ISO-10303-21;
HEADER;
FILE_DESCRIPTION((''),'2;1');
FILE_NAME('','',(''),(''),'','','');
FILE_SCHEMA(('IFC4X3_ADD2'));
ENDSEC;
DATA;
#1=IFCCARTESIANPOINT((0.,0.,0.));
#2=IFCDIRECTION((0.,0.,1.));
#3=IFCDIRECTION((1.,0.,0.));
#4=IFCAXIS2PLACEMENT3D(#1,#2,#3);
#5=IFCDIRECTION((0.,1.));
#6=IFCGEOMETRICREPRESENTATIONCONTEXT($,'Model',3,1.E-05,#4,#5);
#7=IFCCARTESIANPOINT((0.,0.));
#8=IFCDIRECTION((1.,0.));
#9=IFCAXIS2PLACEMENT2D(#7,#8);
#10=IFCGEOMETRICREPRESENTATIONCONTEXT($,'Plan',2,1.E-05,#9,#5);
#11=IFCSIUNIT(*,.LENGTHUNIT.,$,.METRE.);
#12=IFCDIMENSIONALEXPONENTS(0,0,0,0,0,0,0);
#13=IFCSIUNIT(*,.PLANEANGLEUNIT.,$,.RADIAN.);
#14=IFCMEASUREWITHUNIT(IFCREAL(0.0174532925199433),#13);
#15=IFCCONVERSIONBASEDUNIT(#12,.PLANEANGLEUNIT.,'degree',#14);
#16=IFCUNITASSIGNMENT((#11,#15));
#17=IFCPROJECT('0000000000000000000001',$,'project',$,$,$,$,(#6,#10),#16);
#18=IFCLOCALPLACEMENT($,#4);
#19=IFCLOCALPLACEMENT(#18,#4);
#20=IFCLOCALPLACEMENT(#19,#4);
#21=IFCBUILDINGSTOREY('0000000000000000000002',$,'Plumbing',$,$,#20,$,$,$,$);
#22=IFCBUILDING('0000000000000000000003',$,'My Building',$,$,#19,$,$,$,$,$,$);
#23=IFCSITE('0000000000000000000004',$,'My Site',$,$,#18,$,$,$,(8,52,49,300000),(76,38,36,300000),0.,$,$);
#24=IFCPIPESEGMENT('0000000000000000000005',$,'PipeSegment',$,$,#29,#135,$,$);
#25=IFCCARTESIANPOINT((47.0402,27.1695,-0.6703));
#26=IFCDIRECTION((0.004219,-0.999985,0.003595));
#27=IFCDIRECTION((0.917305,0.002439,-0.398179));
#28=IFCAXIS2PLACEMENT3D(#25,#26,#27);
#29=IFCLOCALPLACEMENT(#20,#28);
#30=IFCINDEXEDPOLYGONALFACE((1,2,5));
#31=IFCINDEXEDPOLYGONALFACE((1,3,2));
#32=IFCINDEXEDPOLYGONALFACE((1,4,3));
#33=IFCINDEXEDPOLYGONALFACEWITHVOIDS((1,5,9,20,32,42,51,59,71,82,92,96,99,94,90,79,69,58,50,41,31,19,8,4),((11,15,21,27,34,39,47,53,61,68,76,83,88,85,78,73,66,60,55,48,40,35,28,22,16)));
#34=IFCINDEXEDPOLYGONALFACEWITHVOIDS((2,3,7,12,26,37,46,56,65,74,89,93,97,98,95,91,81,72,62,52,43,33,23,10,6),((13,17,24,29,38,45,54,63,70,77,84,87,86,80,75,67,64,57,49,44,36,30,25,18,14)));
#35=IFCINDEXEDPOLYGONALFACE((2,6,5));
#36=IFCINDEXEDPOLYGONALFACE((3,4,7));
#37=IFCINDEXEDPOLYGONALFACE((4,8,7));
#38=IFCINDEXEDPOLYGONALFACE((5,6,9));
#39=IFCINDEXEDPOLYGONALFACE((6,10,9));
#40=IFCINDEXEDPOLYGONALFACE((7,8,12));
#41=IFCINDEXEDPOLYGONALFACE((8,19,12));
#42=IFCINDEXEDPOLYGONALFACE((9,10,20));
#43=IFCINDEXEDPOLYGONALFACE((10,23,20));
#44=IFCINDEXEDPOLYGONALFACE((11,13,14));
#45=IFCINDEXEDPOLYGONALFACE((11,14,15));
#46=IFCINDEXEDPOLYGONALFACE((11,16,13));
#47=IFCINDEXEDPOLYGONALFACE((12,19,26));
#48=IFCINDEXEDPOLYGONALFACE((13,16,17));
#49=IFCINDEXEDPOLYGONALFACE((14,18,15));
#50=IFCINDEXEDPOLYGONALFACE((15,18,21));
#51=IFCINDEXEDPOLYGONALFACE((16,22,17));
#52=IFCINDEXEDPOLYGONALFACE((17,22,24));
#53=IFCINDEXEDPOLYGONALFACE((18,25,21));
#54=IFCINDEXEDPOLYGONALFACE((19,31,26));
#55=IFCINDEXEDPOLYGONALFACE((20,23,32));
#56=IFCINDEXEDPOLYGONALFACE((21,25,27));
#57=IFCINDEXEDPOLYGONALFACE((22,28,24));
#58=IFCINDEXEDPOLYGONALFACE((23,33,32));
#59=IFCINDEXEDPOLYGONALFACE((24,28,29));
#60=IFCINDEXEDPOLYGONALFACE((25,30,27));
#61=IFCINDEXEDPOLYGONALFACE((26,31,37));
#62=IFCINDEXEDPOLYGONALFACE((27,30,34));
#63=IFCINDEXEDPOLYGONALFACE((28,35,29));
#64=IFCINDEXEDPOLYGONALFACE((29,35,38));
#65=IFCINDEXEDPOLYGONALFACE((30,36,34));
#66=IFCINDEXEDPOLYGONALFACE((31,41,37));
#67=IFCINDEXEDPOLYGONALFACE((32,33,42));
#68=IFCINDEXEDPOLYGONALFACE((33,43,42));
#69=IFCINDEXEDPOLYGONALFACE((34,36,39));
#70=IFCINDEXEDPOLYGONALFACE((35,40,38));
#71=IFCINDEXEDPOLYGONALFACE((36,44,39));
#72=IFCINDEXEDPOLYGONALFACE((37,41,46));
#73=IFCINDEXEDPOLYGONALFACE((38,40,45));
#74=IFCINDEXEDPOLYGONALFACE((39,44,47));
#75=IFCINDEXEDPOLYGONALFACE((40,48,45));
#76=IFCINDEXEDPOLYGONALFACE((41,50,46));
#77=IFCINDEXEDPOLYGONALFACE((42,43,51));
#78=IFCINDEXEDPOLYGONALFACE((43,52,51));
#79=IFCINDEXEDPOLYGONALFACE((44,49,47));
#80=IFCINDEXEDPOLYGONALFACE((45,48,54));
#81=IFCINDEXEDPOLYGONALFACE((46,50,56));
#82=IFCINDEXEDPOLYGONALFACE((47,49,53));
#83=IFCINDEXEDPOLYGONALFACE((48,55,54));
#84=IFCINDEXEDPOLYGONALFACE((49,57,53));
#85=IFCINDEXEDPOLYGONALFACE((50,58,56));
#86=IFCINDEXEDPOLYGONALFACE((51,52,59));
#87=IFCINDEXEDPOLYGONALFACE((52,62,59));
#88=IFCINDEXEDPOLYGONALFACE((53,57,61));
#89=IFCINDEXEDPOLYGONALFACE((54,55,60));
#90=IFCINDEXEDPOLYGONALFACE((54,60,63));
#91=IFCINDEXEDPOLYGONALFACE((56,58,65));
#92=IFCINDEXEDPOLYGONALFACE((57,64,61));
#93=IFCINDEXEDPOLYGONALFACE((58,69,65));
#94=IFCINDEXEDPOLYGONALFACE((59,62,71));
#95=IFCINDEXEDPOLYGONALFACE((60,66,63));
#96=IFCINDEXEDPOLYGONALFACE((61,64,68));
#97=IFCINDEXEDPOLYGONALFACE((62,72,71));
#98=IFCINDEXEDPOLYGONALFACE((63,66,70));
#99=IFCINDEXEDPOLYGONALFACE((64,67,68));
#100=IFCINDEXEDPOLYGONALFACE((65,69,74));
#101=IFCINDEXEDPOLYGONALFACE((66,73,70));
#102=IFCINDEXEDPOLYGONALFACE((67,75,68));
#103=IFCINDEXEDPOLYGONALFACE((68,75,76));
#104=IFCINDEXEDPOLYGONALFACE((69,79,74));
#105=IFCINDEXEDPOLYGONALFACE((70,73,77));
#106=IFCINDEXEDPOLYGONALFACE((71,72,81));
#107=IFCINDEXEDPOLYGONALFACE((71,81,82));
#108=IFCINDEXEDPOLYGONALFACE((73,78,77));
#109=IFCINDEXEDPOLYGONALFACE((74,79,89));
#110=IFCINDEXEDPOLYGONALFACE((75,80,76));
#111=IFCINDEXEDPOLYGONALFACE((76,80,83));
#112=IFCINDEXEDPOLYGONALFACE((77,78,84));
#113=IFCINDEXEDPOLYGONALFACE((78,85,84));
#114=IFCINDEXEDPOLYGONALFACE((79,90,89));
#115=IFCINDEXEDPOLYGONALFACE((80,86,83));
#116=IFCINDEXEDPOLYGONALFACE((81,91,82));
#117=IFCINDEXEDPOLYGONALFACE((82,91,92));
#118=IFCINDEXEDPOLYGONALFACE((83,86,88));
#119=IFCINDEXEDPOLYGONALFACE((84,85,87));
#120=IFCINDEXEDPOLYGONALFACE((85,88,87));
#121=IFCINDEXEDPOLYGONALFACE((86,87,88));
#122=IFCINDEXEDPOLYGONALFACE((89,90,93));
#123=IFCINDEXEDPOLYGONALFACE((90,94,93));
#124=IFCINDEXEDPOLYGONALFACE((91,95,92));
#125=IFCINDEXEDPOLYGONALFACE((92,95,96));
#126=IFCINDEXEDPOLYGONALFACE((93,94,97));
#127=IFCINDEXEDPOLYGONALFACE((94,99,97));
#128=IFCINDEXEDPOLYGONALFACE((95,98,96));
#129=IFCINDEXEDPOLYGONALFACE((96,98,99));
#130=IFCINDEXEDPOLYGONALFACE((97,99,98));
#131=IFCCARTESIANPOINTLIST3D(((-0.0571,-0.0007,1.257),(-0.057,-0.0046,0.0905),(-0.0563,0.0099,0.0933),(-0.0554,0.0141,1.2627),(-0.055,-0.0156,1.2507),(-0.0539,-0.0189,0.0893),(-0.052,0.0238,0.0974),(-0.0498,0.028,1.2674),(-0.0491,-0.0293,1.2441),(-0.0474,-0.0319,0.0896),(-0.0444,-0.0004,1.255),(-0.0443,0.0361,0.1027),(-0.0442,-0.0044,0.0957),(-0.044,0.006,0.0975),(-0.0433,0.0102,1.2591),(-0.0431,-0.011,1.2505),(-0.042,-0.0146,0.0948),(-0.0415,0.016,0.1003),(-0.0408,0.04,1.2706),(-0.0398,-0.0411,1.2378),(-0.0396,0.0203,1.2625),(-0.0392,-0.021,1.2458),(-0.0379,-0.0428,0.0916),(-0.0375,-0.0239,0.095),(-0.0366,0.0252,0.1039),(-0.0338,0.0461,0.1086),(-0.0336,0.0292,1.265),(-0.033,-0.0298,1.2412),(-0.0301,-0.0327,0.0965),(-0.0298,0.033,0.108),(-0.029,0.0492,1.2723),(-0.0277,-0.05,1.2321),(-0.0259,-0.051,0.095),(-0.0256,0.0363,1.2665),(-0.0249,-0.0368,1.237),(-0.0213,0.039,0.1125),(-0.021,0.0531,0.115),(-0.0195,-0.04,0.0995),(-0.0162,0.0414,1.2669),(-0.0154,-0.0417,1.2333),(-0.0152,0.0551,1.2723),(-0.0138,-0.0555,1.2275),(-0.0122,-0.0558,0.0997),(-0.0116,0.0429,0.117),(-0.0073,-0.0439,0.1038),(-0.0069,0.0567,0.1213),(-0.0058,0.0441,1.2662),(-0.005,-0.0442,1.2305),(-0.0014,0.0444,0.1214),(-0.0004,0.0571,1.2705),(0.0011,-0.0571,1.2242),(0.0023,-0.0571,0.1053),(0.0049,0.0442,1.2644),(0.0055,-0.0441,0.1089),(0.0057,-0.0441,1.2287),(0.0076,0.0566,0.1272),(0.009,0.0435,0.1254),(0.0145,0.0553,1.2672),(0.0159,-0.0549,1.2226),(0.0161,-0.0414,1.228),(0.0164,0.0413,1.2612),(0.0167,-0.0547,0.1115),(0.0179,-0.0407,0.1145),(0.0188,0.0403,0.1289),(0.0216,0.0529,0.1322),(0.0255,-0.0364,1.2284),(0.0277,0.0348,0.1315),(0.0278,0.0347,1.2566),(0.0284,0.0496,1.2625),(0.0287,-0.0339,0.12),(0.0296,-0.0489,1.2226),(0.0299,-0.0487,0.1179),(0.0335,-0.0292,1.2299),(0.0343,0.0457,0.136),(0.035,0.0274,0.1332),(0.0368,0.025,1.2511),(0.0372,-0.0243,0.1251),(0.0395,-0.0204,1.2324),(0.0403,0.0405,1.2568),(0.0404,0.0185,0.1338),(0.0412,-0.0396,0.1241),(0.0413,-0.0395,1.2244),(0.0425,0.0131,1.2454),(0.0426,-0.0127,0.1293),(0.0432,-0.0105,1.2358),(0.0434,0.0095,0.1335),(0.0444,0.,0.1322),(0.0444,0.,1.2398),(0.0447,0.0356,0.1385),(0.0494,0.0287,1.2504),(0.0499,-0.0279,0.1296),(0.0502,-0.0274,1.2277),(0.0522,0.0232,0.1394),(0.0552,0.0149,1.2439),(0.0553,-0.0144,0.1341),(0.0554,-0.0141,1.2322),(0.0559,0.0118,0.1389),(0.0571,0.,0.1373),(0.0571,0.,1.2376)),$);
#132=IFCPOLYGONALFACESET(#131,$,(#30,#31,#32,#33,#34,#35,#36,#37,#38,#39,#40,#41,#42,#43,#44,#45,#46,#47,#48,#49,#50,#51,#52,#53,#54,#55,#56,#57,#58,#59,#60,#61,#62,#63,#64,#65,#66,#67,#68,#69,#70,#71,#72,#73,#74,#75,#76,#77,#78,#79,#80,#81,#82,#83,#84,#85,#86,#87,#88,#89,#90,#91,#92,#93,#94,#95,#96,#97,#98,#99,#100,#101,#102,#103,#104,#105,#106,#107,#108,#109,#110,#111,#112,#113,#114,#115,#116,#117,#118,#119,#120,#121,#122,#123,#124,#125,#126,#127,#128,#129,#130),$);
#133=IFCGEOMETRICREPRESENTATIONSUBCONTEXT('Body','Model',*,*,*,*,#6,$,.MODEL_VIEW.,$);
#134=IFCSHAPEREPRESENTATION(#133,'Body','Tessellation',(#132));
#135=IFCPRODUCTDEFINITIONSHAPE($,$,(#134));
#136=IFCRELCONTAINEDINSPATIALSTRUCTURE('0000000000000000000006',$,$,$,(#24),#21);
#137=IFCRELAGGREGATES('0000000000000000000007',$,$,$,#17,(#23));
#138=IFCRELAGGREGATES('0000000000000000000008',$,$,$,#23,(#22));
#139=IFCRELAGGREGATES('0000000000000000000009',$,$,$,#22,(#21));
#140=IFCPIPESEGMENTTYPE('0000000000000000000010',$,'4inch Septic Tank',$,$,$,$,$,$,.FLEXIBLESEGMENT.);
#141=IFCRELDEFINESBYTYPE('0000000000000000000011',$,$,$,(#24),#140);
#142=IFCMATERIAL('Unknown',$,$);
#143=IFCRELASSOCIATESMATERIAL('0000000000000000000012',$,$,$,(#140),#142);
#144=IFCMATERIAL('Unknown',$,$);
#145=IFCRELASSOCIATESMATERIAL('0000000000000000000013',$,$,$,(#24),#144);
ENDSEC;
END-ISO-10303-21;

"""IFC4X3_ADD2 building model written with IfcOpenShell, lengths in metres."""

from ifc_helpers import new_model, entity, si_unit, converted_unit, direction, frame, origin_with_axes, origin_2d_with_axis, place, context, subcontext, project, spatial, hollow_circle, extrude, clip, halfspace, material, material_profile, profile_set, profile_usage, type_object, element, save


model = new_model("IFC4X3_ADD2")

# Units and contexts
model_context = context("Model", 3, precision=1e-05, world=origin_with_axes(), true_north=direction((0.0, 1.0)))
plan_context = context("Plan", 2, precision=1e-05, world=origin_2d_with_axis(), true_north=direction((0.0, 1.0)))
body_context = subcontext(model_context, "Body", "Model", "MODEL_VIEW")
ifc_project = project(units=[si_unit("LENGTHUNIT", "METRE"), converted_unit("PLANEANGLEUNIT", "degree", entity("IfcReal", 0.0174532925199433), si_unit("PLANEANGLEUNIT", "RADIAN"), dimensions=[0, 0, 0, 0, 0, 0, 0])], contexts=[model_context, plan_context])

# Site, building, storey
site_placement = place(None, origin_with_axes())
site = spatial("IfcSite", under=ifc_project, at=site_placement, Name="My Site", RefLatitude=(8, 52, 49, 300000), RefLongitude=(76, 38, 36, 300000), RefElevation=0.0)
building_placement = place(site_placement, origin_with_axes())
building = spatial("IfcBuilding", under=site, at=building_placement, Name="My Building")
storey_placement = place(building_placement, origin_with_axes())
storey = spatial("IfcBuildingStorey", under=building, at=storey_placement, Name="Plumbing")

# Pipe segment
ifc_material_1 = material(Name="Unknown")
ifc_material_profile_1 = material_profile(ifc_material_1, hollow_circle(Radius=0.0571, WallThickness=0.0127))
ifc_profile_set_1 = profile_set([ifc_material_profile_1], Name="blackwater")
ifc_material_2 = material(Name="Unknown")
ifc_material_profile_2 = material_profile(ifc_material_2, hollow_circle(Radius=0.0571, WallThickness=0.0127))
ifc_profile_set_2 = profile_set([ifc_material_profile_2], Name="blackwater")
pipe_segment_type_1 = type_object("IfcPipeSegmentType", Name="4inch Septic Tank", PredefinedType="FLEXIBLESEGMENT", material=ifc_profile_set_2)
ifc_profile_usage_1 = profile_usage(ifc_profile_set_1, cardinal=5)
pipe_segment_1_placement = place(storey_placement, frame((47.0402, 27.1695, -0.6703), z_axis=(0.004219, -0.999985, 0.003595), x_axis=(0.917305, 0.002439, -0.398179)))
element("IfcPipeSegment", 1, at=pipe_segment_1_placement, inside=storey, type_object=pipe_segment_type_1, material=ifc_profile_usage_1, Name="PipeSegment", context=body_context, shape_type="Clipping", body=[
    clip(clip(extrude(hollow_circle(Radius=0.0571, WallThickness=0.0127), origin_with_axes(), (0.0, 0.0, 1.0), 1.3617), halfspace(frame((0.0411, -0.1712, 0.1012), z_axis=(0.369456, 0.158535, -0.915625), x_axis=(0.394332, -0.918968, 0.0)), False)), halfspace(frame((0.0569, -0.0433, 1.2202), z_axis=(0.158546, -0.368844, 0.915869), x_axis=(-0.918721, -0.394908, 0.0)), False)),
])

save(model, "model.ifc")
